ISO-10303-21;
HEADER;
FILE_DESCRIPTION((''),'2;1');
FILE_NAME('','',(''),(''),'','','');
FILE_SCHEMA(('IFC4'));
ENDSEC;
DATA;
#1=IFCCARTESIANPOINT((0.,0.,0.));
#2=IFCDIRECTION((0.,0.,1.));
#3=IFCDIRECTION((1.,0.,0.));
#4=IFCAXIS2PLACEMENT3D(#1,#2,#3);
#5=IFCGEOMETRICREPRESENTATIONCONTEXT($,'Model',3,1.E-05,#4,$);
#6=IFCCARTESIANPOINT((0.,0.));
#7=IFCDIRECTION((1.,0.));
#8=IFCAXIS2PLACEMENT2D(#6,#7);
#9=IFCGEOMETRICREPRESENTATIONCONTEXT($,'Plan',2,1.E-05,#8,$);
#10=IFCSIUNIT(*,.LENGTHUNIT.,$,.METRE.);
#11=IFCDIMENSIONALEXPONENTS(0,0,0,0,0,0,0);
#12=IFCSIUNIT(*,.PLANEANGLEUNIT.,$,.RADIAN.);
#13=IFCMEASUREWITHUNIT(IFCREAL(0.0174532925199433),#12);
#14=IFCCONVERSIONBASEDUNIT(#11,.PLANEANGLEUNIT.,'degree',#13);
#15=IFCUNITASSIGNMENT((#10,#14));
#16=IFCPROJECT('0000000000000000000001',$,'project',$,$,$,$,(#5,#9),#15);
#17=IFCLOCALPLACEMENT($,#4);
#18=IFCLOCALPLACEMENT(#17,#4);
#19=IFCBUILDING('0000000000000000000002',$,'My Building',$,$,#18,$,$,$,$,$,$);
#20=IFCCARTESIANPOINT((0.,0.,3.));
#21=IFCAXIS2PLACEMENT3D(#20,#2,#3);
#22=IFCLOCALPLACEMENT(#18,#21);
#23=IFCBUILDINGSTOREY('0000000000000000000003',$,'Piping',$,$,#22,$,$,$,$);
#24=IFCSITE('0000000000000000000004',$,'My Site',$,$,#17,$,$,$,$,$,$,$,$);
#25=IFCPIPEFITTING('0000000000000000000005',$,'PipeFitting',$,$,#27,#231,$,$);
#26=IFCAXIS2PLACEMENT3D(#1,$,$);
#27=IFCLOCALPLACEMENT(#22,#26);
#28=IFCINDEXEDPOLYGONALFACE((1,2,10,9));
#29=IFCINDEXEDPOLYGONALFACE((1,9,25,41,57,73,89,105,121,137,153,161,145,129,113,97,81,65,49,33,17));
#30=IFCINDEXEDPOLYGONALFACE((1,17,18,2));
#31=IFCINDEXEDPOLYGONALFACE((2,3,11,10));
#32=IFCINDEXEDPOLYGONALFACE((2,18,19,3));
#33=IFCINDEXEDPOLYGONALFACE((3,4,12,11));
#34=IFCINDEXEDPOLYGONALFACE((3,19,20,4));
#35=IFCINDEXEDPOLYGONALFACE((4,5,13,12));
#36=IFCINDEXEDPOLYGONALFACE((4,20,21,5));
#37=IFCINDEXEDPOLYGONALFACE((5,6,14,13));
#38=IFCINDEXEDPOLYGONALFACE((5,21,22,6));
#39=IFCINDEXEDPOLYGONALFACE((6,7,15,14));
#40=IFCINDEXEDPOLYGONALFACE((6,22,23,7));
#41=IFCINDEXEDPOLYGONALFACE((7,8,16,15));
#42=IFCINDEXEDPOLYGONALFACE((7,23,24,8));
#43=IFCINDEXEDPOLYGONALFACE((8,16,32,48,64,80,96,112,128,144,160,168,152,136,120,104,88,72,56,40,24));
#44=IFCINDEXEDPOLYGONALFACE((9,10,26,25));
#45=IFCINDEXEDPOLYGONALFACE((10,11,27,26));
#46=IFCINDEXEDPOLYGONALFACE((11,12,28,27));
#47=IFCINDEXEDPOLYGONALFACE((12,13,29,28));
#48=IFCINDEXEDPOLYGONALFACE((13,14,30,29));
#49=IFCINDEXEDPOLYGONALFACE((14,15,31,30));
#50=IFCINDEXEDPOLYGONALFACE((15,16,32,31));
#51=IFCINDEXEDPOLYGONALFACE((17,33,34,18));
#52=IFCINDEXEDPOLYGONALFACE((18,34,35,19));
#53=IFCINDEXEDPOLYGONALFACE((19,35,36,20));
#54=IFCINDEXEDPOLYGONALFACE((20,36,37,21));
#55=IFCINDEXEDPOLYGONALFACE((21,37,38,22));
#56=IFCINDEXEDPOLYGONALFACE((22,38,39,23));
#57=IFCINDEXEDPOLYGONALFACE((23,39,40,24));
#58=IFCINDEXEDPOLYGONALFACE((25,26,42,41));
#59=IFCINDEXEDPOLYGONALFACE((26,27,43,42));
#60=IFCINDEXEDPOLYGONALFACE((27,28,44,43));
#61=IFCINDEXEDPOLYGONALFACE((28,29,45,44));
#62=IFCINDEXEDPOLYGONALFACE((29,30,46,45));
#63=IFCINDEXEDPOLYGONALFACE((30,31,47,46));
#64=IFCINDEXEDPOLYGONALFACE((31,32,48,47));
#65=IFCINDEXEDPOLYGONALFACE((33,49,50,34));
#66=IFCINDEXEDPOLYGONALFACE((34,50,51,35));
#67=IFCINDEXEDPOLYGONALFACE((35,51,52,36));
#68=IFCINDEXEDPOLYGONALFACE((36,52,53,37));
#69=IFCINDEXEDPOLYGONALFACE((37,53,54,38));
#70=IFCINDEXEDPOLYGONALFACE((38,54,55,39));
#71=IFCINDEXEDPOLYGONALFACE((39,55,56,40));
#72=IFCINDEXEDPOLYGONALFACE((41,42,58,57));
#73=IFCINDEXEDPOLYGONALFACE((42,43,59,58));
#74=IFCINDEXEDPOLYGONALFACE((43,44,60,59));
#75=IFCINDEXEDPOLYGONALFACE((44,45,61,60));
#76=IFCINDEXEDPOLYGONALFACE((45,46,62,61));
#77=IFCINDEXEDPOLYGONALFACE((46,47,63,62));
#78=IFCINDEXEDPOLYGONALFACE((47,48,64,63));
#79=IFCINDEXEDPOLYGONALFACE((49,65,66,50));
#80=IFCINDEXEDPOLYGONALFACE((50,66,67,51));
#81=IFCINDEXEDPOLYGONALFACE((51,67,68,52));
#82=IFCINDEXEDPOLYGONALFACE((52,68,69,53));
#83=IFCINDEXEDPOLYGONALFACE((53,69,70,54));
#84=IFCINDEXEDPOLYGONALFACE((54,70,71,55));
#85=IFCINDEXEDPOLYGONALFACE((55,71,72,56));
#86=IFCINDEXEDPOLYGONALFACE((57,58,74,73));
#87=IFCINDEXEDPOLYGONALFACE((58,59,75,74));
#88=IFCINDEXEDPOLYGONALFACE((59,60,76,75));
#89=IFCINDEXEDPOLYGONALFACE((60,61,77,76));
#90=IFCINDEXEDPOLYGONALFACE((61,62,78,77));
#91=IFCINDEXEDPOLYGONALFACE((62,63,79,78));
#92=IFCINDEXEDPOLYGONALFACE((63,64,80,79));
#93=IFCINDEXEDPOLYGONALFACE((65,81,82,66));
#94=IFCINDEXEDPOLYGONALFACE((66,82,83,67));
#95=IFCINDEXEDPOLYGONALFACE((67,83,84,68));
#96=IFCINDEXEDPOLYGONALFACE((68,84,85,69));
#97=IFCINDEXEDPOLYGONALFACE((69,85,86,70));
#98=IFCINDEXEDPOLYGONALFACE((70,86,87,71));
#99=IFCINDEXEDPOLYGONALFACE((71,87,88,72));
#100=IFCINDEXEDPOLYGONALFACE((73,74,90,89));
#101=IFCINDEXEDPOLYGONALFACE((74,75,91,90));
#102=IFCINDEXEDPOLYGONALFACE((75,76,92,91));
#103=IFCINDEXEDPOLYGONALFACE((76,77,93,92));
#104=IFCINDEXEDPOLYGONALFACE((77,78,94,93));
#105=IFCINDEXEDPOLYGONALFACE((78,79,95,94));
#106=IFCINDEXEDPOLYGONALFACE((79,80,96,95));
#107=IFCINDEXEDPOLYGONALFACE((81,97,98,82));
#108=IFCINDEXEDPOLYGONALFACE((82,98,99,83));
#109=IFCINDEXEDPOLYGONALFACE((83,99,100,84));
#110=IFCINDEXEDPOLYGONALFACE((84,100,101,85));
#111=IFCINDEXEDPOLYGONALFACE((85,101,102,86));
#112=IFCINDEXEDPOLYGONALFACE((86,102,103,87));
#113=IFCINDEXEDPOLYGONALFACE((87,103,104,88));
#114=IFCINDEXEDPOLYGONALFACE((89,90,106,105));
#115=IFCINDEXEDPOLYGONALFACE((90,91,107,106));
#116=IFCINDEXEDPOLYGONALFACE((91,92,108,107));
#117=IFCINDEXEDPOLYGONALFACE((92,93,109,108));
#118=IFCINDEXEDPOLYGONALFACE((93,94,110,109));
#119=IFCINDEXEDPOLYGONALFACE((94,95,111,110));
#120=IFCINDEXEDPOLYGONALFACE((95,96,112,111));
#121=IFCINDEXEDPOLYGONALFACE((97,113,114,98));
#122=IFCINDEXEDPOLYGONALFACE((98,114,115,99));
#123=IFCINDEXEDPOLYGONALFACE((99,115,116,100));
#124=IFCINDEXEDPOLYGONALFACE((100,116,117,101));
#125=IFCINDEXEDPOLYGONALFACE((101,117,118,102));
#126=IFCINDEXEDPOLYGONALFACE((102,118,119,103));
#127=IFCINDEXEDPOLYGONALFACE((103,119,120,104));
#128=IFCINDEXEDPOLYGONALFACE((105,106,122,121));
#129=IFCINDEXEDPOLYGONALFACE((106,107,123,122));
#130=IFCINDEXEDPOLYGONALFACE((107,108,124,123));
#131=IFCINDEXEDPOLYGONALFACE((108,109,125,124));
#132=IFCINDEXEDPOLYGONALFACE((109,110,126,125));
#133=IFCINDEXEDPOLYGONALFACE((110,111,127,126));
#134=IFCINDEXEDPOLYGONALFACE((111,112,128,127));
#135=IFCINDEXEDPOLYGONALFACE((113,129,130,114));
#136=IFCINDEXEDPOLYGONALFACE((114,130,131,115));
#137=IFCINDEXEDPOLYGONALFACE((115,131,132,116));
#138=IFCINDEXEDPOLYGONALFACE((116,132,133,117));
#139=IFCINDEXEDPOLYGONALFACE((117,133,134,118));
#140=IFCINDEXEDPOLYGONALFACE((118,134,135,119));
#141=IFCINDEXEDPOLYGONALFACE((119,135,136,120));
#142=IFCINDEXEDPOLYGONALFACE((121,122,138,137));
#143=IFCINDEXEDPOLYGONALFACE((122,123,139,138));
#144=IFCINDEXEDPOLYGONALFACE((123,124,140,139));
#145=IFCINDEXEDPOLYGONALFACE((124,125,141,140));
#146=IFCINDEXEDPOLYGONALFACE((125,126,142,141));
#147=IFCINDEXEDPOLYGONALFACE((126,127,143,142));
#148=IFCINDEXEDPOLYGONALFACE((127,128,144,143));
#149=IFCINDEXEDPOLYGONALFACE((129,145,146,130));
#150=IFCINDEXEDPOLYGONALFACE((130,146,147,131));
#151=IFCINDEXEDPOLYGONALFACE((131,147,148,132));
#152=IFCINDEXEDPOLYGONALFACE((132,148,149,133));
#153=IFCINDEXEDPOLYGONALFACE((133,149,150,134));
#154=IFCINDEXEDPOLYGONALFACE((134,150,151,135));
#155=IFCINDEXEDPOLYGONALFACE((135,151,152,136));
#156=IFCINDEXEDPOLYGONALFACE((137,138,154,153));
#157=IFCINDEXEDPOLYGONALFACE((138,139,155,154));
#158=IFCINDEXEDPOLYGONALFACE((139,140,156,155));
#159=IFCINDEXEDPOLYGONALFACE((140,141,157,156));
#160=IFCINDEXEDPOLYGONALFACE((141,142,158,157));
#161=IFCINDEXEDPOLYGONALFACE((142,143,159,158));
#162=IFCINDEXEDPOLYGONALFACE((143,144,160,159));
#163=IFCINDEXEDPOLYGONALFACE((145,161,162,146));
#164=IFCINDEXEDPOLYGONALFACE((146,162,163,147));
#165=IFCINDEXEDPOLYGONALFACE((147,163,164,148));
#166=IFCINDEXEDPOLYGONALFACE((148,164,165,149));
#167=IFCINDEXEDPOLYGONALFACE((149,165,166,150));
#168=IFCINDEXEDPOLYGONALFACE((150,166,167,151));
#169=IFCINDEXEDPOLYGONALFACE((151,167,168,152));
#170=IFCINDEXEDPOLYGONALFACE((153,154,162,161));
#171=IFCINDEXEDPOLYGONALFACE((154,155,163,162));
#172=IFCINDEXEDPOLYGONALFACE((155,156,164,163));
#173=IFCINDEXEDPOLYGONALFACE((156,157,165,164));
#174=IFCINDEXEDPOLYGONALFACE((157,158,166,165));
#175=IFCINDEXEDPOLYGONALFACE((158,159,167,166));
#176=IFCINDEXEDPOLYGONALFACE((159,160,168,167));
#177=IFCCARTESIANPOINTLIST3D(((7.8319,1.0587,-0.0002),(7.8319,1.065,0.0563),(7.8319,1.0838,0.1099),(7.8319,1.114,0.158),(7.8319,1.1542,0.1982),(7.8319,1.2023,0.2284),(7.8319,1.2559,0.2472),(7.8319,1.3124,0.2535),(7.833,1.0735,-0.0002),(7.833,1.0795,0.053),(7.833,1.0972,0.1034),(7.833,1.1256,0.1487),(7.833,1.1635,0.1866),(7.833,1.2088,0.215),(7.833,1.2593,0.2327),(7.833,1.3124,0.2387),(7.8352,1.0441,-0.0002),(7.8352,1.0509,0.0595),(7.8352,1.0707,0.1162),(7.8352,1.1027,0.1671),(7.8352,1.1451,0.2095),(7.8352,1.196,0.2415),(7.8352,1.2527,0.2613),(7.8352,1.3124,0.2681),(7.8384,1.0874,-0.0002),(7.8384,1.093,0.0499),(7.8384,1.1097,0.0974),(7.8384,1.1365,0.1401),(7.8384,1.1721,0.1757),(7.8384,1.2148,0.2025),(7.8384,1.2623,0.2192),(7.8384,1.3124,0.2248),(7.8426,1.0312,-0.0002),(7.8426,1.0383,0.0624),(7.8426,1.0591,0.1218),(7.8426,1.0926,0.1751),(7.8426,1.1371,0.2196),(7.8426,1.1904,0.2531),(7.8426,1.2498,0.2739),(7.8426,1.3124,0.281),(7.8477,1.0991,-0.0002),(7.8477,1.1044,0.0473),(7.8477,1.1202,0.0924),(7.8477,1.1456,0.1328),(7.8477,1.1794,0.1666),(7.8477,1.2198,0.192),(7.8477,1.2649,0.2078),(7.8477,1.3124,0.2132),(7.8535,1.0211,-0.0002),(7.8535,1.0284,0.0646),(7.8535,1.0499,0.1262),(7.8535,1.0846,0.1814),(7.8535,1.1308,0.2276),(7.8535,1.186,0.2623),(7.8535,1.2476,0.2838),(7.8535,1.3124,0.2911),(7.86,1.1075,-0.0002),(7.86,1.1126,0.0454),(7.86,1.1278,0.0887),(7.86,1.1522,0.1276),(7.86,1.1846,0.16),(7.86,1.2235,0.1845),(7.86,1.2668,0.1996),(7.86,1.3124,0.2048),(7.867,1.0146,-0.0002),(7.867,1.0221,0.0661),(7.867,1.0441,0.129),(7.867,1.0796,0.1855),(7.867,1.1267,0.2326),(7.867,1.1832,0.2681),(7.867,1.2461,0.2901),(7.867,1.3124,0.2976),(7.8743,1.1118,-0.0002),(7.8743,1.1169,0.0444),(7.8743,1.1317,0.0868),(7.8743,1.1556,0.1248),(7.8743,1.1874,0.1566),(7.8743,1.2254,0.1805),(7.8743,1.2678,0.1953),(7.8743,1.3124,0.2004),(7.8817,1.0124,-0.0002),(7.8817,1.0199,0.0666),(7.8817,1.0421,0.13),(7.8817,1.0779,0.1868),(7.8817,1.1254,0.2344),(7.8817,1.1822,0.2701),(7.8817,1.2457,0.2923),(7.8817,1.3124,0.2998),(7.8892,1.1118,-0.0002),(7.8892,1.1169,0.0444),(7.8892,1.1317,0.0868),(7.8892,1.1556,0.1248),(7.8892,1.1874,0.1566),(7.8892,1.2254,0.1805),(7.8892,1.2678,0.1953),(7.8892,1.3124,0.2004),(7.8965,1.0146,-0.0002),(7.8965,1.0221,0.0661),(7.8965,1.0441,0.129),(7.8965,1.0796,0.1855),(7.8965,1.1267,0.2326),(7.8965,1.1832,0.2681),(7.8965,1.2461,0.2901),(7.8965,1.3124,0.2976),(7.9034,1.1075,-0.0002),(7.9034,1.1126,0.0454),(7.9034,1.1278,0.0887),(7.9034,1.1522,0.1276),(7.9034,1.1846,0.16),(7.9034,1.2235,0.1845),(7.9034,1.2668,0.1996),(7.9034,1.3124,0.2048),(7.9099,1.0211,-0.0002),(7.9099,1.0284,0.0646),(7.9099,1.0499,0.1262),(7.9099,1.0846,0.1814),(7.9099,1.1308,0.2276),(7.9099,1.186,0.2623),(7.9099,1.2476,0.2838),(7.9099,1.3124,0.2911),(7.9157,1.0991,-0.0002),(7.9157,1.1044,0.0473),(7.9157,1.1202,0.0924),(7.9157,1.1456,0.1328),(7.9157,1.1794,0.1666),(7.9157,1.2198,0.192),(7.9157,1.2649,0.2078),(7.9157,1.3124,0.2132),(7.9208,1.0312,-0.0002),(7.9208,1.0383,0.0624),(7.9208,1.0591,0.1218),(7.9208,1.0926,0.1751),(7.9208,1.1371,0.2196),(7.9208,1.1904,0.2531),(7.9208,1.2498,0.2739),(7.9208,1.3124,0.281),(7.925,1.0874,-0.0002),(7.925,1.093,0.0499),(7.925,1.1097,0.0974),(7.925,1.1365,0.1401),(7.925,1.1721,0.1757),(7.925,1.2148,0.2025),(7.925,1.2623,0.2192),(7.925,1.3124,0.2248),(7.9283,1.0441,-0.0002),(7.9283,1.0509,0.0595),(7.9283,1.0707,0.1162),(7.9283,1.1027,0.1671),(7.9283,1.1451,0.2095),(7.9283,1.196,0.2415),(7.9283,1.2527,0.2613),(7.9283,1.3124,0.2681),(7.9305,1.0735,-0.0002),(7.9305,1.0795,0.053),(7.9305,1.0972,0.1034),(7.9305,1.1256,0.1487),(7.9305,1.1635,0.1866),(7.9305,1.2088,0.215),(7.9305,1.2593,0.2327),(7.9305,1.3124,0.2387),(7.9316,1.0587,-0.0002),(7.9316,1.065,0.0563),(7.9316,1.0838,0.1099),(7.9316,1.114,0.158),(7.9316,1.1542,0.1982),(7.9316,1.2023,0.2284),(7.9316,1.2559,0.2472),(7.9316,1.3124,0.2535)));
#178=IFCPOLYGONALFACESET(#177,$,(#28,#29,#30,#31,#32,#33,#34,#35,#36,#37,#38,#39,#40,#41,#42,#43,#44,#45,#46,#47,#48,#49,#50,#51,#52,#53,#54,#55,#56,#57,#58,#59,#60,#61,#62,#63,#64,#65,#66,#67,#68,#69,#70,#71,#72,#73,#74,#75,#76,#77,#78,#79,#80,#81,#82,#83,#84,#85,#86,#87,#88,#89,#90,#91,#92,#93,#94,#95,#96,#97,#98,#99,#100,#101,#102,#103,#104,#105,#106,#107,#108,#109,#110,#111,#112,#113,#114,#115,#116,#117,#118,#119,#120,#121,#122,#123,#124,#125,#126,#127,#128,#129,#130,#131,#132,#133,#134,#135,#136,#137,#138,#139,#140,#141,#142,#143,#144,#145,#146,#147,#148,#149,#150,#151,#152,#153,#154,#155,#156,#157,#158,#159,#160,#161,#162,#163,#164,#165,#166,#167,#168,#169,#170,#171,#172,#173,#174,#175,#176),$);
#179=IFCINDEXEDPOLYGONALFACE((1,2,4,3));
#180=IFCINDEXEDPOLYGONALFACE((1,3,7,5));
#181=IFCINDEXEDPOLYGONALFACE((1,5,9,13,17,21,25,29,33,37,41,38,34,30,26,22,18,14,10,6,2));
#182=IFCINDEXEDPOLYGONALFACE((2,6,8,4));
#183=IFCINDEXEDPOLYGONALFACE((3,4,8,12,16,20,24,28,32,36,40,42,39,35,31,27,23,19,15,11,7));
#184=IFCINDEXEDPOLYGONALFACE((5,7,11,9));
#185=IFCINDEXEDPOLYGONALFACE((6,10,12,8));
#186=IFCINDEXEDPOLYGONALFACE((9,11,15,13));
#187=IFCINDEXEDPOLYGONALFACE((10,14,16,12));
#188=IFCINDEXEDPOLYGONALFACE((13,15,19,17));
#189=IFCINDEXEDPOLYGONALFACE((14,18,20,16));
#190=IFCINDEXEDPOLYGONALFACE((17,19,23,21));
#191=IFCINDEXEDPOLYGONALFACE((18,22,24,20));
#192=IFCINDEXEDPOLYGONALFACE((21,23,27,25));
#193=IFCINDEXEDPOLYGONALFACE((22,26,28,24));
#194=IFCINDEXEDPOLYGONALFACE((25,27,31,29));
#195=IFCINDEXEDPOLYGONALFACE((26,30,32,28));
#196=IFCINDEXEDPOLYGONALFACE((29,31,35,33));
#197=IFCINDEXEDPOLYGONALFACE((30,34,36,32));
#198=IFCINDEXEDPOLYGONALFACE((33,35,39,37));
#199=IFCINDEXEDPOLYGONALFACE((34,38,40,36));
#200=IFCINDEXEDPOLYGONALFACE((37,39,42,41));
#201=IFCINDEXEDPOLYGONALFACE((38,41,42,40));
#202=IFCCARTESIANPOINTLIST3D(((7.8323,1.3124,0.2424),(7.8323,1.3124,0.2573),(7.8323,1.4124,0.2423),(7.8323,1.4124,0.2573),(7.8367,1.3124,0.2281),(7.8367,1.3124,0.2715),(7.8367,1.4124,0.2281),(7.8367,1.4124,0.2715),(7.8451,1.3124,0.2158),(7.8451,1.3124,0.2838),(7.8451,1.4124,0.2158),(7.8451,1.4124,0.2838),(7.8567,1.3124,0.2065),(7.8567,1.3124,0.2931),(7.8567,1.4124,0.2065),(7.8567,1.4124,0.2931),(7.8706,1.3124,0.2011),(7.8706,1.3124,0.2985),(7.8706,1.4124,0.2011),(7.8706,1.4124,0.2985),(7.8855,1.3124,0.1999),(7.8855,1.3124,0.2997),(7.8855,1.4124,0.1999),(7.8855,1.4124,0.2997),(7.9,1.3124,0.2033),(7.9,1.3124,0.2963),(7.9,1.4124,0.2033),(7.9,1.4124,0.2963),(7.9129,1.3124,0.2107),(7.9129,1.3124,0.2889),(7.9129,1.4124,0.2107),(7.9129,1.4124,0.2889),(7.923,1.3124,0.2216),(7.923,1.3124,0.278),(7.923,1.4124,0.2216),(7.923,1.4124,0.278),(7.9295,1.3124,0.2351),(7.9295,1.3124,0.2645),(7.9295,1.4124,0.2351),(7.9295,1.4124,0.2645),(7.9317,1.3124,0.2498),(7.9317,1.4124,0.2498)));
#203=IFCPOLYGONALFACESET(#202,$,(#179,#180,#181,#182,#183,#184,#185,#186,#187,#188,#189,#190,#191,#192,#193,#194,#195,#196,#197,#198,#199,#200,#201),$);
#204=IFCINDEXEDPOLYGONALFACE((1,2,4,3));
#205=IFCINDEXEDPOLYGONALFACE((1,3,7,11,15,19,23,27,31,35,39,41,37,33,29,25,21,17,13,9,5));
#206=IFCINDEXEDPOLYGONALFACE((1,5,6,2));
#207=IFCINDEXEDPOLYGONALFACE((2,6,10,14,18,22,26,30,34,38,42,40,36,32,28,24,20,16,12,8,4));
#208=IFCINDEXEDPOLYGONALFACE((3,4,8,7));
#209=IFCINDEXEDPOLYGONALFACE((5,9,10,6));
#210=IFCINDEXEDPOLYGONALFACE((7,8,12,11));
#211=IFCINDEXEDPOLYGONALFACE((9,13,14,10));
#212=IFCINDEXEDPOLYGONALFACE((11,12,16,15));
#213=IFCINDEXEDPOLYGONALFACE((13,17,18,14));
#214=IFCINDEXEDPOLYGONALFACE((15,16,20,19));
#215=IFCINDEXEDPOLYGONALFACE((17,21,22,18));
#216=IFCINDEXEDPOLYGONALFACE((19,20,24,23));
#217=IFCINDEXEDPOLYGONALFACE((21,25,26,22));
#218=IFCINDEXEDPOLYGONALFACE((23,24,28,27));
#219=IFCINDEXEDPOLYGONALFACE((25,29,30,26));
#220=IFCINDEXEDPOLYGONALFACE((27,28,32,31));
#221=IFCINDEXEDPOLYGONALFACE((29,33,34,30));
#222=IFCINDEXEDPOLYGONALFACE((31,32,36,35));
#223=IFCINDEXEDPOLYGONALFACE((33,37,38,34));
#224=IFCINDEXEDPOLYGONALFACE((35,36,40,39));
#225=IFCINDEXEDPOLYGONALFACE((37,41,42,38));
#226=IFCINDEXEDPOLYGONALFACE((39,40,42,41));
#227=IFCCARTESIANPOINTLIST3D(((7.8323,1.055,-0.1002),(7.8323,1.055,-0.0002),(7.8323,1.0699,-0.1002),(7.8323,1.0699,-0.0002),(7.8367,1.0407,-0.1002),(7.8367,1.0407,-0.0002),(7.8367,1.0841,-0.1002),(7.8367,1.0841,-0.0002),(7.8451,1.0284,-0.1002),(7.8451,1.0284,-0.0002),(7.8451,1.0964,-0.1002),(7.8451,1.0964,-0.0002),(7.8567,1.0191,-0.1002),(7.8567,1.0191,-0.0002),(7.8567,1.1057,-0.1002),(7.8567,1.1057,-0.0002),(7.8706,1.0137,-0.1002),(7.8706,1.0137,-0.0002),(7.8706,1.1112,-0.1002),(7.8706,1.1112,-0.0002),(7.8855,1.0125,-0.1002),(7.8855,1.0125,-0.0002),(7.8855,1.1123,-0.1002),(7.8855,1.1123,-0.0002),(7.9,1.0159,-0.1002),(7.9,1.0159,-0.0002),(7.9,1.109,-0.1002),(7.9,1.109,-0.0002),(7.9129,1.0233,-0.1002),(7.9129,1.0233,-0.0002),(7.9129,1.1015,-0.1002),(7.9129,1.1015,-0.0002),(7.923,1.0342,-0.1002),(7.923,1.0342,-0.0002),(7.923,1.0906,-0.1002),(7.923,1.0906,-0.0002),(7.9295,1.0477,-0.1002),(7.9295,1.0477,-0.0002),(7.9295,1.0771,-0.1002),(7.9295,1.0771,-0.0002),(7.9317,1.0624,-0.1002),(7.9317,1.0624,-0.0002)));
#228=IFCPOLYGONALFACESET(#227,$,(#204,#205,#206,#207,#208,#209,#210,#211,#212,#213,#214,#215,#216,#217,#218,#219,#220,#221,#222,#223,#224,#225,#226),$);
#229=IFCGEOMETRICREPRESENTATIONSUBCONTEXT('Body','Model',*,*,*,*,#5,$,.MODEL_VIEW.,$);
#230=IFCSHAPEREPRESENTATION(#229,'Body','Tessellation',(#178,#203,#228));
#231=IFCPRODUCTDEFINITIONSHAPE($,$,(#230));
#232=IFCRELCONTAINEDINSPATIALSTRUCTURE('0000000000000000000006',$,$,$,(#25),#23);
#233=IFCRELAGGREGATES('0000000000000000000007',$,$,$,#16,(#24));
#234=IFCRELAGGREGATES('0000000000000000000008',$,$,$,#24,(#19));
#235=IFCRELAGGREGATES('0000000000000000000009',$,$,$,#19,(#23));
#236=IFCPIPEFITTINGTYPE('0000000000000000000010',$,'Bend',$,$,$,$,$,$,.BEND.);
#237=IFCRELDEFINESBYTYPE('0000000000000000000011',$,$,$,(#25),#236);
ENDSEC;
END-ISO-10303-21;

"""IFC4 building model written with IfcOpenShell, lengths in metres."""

from ifc_helpers import new_model, entity, si_unit, converted_unit, frame, origin_with_axes, origin_2d_with_axis, place, context, subcontext, project, spatial, circle, extrude, source, transform, mapped, type_object, type_shapes, element, save


model = new_model("IFC4")

# Units and contexts
model_context = context("Model", 3, precision=1e-05, world=origin_with_axes())
plan_context = context("Plan", 2, precision=1e-05, world=origin_2d_with_axis())
body_context = subcontext(model_context, "Body", "Model", "MODEL_VIEW")
ifc_project = project(units=[si_unit("LENGTHUNIT", "METRE"), converted_unit("PLANEANGLEUNIT", "degree", entity("IfcReal", 0.0174532925199433), si_unit("PLANEANGLEUNIT", "RADIAN"), dimensions=[0, 0, 0, 0, 0, 0, 0])], contexts=[model_context, plan_context])

# Site, building, storey
site_placement = place(None, origin_with_axes())
site = spatial("IfcSite", under=ifc_project, at=site_placement, Name="My Site")
building_placement = place(site_placement, origin_with_axes())
building = spatial("IfcBuilding", under=site, at=building_placement, Name="My Building")
storey_placement = place(building_placement, frame((0.0, 0.0, 3.0), z_axis=(0.0, 0.0, 1.0), x_axis=(1.0, 0.0, 0.0)))
storey = spatial("IfcBuildingStorey", under=building, at=storey_placement, Name="Piping")

# Pipe fitting
pipe_fitting_type_1 = type_object("IfcPipeFittingType", Name="Bend", PredefinedType="BEND")
shared_shape = source(origin_with_axes(), body_context, "Body", "SolidModel", [
    entity("IfcSweptDiskSolid", entity("IfcIndexedPolyCurve", entity("IfcCartesianPointList3D", [[0.0, 0.0, 0.1], [0.0, -0.0732, 0.2768], [0.0, -0.25, 0.35]]), [entity("IfcArcIndex", [1, 2, 3])]), 0.05),
    extrude(circle(Radius=0.05), origin_with_axes(), (0.0, 0.0, 1.0), 0.1),
    extrude(circle(Radius=0.05), frame((0.0, -0.25, 0.35), z_axis=(0.0, -1.0, -0.00003), x_axis=(1.0, 0.0, 0.0)), (0.0, 0.0, 1.0), 0.1),
])
type_shapes(pipe_fitting_type_1, [shared_shape])
for number, where, z_axis, x_axis, name in (
    (1, (7.8817, 1.4124, 0.2498), (0.0, -1.0, 0.000008), (1.0, 0.0, 0.0), "PipeFitting"),
):
    element("IfcPipeFitting", number, at=place(storey_placement, frame(where, z_axis=z_axis, x_axis=x_axis)), inside=storey, type_object=pipe_fitting_type_1, Name=name, context=body_context, shape_type="MappedRepresentation", body=[
        mapped(shared_shape, transform((0.0, 0.0, 0.0), x_axis=(1.0, 0.0, 0.0), y_axis=(0.0, 1.0, 0.0), z_axis=(0.0, 0.0, 1.0), scale=1.0)),
    ])

save(model, "model.ifc")
